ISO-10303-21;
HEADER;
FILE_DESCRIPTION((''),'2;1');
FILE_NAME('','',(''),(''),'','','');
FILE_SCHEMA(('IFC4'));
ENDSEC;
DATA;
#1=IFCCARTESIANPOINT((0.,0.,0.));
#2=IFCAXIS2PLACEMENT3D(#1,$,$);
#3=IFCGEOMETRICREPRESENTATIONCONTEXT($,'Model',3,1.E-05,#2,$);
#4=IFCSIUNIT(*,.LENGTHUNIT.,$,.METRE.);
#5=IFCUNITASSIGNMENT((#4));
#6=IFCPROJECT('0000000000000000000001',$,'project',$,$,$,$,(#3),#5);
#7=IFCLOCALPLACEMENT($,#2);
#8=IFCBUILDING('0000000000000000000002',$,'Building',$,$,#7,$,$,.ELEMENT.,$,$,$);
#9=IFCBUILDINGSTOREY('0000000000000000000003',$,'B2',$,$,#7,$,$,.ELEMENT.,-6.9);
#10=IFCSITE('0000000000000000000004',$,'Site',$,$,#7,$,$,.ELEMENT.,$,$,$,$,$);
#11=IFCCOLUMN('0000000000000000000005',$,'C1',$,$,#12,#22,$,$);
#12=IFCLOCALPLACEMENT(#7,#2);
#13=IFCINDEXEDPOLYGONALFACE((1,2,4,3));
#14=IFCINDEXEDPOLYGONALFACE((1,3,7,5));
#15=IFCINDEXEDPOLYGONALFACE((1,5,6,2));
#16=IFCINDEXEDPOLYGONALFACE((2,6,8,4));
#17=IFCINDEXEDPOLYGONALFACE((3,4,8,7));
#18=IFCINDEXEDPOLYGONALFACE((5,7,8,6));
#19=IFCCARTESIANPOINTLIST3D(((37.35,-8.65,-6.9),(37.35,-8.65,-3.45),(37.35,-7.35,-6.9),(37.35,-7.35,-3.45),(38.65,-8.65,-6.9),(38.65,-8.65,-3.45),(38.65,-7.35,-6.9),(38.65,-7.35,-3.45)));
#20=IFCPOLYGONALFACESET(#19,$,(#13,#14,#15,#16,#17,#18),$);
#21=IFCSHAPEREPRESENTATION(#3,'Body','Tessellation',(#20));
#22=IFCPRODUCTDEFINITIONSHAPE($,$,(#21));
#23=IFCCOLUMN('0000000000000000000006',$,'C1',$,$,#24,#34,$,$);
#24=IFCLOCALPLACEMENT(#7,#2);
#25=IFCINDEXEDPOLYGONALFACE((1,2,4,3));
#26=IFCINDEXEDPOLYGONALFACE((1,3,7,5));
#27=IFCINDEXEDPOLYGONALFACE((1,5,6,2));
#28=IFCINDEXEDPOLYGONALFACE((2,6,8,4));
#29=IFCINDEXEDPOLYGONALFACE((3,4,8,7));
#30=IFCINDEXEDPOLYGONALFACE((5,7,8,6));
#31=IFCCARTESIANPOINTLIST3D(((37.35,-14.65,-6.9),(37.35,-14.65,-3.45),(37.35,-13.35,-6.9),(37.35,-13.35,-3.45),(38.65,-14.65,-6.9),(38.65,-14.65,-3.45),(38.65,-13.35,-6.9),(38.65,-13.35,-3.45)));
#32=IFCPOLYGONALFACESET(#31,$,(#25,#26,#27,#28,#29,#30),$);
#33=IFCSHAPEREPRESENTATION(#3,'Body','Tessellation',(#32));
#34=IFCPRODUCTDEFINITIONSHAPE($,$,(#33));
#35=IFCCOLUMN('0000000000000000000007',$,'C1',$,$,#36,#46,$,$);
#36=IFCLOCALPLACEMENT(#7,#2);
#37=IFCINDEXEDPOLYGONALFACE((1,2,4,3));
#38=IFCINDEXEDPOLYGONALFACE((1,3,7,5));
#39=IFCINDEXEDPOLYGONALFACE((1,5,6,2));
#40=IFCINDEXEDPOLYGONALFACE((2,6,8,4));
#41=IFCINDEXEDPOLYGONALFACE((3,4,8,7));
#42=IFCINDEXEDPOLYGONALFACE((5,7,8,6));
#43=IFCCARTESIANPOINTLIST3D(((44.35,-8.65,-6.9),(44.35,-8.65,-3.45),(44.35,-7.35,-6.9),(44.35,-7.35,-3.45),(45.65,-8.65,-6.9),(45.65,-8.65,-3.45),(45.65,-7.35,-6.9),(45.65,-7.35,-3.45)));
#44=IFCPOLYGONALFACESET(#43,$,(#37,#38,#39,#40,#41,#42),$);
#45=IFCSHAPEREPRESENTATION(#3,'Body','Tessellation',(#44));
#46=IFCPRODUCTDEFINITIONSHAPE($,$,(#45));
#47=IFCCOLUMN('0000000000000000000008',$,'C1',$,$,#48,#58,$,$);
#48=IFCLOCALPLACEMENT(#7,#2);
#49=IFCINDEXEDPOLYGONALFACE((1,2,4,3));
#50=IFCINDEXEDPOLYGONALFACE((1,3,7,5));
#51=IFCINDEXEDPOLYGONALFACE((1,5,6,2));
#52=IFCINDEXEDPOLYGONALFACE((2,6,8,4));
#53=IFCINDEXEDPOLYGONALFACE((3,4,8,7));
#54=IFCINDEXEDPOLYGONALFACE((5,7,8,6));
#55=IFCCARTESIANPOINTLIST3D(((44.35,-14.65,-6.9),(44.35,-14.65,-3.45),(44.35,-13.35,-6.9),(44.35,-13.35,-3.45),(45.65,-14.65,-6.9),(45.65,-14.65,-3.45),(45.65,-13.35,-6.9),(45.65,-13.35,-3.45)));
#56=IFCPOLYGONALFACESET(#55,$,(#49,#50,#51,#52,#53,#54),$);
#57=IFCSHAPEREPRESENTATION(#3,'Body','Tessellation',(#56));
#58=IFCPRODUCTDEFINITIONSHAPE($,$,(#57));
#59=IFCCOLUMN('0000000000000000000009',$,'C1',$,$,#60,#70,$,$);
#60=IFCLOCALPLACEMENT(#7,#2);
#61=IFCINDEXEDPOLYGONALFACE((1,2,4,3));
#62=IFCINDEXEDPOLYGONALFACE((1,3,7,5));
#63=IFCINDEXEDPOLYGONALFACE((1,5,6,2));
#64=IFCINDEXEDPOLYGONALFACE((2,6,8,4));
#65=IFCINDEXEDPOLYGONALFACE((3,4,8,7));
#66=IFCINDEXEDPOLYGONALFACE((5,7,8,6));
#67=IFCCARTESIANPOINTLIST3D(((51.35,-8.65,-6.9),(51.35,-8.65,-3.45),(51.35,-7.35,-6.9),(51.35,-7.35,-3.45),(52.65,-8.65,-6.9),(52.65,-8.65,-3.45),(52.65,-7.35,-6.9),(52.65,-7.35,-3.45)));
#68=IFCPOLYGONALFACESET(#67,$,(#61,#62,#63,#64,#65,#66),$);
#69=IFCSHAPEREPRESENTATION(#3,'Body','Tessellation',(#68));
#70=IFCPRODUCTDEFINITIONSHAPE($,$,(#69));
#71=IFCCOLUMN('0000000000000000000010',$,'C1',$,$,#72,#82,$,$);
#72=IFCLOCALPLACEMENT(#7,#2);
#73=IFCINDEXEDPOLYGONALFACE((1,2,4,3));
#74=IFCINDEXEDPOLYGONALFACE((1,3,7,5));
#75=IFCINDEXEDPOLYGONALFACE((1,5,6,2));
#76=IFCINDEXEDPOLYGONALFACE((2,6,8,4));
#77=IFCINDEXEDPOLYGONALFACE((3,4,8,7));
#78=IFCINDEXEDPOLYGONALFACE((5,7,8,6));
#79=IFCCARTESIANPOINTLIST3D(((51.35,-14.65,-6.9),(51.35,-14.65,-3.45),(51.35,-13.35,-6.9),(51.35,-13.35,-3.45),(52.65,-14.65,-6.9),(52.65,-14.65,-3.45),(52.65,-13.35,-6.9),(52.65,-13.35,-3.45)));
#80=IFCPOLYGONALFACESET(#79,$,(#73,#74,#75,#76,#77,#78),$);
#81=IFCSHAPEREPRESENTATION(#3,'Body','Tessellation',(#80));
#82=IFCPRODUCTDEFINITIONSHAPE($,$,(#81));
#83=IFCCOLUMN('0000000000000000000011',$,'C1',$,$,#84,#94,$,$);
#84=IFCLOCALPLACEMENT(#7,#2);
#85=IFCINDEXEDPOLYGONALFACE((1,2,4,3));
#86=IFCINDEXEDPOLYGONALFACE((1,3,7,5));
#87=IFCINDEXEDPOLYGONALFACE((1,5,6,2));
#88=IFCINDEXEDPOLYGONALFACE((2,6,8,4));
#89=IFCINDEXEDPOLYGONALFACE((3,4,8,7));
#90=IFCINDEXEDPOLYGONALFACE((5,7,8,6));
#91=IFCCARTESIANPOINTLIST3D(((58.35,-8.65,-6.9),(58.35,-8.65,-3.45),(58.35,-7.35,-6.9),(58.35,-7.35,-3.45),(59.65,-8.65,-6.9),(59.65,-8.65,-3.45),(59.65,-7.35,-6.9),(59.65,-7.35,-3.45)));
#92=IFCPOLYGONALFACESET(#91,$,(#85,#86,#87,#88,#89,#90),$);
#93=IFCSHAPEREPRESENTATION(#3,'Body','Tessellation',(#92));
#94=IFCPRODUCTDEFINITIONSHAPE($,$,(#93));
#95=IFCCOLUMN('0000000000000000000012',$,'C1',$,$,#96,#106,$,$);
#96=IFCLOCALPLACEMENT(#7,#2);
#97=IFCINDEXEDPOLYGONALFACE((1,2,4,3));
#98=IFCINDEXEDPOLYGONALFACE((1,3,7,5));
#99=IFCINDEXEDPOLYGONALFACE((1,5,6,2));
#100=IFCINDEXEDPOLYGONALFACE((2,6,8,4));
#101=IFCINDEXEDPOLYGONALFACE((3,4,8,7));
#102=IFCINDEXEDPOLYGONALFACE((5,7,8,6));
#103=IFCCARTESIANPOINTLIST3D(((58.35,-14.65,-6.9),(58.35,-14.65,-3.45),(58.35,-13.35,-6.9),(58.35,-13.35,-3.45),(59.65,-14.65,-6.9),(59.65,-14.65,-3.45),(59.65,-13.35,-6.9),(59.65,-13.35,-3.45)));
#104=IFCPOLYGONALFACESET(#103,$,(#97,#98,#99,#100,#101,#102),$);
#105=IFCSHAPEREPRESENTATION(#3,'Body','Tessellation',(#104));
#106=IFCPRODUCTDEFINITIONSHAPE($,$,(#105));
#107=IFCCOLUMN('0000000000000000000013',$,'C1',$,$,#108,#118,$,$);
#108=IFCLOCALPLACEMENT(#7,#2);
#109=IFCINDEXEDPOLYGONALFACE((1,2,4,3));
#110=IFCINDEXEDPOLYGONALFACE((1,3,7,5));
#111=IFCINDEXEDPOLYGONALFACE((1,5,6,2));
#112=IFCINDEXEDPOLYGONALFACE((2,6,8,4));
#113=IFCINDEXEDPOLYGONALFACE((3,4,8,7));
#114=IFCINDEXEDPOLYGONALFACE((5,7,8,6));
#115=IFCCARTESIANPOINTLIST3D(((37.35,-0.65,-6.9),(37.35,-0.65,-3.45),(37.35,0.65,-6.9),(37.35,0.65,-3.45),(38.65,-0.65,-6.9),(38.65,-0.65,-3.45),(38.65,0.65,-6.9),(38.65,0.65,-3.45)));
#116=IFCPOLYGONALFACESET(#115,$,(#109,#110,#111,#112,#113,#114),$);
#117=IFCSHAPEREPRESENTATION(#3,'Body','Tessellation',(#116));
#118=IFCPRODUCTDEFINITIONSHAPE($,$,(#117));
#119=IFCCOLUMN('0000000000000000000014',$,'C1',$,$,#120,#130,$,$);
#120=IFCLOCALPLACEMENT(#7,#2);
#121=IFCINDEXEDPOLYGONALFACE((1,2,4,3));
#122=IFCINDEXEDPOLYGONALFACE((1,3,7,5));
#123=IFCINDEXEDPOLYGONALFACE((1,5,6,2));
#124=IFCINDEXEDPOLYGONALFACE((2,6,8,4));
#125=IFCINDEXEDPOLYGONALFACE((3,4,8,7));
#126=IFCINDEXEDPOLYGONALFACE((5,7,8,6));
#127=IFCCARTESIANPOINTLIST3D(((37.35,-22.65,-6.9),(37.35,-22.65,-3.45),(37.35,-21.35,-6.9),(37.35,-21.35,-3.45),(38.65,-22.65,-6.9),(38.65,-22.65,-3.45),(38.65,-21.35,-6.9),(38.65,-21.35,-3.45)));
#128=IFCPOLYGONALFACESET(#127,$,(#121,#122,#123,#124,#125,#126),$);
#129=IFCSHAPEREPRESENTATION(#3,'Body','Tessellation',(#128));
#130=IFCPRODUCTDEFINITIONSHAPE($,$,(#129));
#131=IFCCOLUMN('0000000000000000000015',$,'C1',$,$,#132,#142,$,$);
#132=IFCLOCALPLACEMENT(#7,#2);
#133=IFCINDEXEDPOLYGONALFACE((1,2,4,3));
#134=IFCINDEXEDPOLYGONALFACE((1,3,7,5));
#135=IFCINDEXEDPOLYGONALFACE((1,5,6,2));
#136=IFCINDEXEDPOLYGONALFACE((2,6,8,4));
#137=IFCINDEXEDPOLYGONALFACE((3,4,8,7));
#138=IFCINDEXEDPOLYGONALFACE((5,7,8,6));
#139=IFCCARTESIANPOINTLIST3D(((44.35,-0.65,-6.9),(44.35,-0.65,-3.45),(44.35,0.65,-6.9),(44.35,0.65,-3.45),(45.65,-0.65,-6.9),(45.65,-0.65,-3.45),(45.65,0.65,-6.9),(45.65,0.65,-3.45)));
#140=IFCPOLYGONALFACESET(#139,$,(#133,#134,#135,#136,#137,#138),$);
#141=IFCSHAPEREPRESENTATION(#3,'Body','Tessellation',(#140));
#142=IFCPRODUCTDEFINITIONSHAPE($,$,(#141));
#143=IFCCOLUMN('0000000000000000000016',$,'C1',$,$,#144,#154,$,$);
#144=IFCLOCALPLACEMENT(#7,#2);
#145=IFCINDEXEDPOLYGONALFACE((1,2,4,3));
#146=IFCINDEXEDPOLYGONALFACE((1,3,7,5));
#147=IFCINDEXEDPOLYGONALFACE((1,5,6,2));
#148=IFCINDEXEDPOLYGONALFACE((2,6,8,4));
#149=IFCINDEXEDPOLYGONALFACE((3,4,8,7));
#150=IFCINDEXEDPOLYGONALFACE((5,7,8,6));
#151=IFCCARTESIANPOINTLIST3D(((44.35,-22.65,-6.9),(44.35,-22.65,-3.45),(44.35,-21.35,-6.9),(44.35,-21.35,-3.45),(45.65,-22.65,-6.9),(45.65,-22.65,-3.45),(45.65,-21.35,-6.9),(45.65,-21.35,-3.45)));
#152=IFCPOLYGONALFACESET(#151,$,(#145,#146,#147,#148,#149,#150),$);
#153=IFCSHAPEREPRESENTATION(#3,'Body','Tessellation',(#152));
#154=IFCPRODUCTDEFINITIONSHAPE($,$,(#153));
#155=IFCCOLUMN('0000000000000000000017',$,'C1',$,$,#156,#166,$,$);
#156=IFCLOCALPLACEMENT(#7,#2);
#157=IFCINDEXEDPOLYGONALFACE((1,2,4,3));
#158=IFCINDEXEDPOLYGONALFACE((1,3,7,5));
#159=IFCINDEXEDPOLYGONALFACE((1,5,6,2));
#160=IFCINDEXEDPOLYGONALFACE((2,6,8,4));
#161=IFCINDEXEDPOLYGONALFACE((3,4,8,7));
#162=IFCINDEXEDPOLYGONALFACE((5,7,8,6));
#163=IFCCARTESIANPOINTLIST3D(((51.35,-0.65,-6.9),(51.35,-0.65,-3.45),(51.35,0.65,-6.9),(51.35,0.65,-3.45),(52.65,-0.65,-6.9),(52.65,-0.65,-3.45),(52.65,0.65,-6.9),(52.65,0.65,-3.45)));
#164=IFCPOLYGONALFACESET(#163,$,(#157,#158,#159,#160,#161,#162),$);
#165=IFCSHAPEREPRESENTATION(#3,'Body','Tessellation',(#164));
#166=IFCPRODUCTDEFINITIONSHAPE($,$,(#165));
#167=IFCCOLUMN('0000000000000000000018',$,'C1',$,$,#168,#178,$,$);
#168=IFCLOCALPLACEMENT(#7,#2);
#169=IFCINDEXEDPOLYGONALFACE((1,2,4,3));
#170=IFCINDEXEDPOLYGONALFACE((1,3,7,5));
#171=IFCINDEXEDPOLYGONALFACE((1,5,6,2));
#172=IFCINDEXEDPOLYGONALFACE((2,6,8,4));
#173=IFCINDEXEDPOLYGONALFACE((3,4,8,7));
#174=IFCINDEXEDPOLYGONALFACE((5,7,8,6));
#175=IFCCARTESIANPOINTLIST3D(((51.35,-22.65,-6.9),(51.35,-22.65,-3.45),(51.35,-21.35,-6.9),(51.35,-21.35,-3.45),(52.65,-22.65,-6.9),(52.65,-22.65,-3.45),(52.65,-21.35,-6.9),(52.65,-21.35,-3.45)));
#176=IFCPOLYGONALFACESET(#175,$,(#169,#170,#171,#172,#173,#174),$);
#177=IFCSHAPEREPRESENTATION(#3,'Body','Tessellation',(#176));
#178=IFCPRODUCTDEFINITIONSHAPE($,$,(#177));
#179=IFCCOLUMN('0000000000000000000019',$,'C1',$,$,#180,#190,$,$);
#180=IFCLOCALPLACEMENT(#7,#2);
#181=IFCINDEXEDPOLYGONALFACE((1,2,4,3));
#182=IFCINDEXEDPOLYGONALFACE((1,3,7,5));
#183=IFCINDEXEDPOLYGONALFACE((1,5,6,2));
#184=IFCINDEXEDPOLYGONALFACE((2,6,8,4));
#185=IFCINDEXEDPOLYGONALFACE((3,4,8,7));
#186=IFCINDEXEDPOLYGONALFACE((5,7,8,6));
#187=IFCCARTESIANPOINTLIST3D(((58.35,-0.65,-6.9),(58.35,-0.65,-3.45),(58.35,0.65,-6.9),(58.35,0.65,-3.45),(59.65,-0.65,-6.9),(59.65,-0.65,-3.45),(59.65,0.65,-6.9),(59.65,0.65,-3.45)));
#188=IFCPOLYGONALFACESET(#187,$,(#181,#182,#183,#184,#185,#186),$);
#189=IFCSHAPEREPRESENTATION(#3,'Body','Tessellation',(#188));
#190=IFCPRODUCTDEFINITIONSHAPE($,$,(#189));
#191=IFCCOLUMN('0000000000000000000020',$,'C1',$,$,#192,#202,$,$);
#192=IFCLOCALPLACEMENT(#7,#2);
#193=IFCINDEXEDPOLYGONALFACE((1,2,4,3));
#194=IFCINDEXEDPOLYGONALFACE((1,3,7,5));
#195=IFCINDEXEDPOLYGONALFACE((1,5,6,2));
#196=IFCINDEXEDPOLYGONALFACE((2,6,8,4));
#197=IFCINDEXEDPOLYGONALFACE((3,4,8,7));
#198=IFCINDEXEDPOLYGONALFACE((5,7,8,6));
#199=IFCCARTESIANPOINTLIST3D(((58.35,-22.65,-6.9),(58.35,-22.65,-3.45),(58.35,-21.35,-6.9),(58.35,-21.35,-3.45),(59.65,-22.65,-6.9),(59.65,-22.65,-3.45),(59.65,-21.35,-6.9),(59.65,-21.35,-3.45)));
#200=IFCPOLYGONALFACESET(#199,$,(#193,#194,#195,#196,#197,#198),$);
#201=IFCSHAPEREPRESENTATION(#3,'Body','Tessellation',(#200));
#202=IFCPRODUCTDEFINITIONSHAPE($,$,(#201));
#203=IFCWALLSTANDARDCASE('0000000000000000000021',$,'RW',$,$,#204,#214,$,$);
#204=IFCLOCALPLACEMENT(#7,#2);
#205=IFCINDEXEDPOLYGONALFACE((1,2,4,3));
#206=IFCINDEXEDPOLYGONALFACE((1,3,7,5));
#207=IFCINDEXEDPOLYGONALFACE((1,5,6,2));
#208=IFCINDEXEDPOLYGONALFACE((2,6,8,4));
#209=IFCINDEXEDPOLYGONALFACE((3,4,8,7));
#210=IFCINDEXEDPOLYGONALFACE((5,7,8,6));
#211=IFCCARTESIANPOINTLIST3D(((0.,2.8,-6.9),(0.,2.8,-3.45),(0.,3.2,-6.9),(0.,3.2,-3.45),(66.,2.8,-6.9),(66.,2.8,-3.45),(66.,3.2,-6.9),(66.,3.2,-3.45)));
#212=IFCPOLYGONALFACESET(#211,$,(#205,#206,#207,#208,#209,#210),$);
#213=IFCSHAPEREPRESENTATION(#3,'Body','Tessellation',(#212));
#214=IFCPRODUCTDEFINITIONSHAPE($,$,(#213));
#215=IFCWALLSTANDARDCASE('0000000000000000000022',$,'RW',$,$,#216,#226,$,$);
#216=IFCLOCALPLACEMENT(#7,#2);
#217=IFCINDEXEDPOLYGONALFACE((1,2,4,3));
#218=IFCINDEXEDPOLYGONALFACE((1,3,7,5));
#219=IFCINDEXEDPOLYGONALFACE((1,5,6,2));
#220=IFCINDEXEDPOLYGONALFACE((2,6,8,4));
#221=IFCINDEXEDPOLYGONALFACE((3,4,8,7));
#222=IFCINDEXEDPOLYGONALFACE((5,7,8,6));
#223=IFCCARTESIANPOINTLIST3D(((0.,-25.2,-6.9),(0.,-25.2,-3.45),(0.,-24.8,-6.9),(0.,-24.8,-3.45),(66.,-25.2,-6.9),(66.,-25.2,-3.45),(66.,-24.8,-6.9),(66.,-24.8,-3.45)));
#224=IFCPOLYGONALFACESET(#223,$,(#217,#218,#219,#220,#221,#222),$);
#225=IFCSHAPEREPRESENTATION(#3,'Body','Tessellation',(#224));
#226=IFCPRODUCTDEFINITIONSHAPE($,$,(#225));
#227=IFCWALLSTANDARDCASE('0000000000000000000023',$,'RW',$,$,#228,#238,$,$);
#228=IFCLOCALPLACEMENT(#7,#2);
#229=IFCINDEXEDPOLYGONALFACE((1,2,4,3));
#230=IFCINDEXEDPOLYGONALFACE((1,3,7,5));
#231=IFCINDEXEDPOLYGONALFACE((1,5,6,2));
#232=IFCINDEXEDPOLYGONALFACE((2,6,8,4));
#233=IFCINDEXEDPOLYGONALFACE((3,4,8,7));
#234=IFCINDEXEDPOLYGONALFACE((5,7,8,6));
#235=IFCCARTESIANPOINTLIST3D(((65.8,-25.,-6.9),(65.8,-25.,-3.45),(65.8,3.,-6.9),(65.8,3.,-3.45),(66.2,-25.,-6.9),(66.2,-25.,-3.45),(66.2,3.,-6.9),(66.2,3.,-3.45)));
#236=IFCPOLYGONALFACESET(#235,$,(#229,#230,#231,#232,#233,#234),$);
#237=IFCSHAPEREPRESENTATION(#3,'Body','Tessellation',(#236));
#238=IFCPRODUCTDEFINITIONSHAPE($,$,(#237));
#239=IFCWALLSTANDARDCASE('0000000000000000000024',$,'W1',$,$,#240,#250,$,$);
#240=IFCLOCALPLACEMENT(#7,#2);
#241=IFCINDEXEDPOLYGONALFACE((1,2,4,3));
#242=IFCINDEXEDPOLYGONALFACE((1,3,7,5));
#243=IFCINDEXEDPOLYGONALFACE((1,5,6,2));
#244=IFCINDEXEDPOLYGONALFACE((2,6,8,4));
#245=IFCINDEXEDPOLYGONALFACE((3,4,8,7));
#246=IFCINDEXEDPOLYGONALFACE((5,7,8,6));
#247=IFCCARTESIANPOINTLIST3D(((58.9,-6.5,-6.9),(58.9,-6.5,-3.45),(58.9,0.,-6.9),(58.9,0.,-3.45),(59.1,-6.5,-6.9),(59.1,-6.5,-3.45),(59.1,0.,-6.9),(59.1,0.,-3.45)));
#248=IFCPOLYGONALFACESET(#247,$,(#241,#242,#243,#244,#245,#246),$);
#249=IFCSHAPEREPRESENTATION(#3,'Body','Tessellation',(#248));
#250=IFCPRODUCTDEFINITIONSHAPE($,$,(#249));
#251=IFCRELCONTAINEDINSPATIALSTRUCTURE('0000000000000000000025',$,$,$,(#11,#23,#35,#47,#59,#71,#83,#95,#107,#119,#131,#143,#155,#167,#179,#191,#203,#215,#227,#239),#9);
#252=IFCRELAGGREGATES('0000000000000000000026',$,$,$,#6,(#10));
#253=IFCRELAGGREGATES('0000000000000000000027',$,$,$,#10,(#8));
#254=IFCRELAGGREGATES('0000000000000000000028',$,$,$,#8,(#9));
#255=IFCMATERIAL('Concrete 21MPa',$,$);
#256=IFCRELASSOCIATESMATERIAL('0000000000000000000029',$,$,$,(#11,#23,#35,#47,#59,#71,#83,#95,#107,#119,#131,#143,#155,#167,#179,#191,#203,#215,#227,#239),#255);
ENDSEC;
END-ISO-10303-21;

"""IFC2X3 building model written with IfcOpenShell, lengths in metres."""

from ifc_helpers import new_model, si_unit, frame, origin, origin_2d, place, context, project, spatial, rectangle, extrude, material, element, save


model = new_model("IFC2X3")

# Units and contexts
model_context = context("Model", 3, precision=1e-05, world=origin())
ifc_project = project(units=[si_unit("LENGTHUNIT", "METRE")], contexts=[model_context])

# Site, building, storey
placement = place(None, origin())
site = spatial("IfcSite", under=ifc_project, at=placement, Name="Site", CompositionType="ELEMENT")
building = spatial("IfcBuilding", under=site, at=placement, Name="Building", CompositionType="ELEMENT")
storey = spatial("IfcBuildingStorey", under=building, at=placement, Name="B2", CompositionType="ELEMENT", Elevation=-6.9)

# Columns
ifc_material_1 = material(Name="Concrete 21MPa")
for number, where, name in (
    (1, (38.0, -8.0, -6.9), "C1"),
    (2, (38.0, -14.0, -6.9), "C1"),
    (3, (45.0, -8.0, -6.9), "C1"),
    (4, (45.0, -14.0, -6.9), "C1"),
    (5, (52.0, -8.0, -6.9), "C1"),
    (6, (52.0, -14.0, -6.9), "C1"),
    (7, (59.0, -8.0, -6.9), "C1"),
    (8, (59.0, -14.0, -6.9), "C1"),
    (9, (38.0, 0.0, -6.9), "C1"),
    (10, (38.0, -22.0, -6.9), "C1"),
    (11, (45.0, 0.0, -6.9), "C1"),
    (12, (45.0, -22.0, -6.9), "C1"),
    (13, (52.0, 0.0, -6.9), "C1"),
    (14, (52.0, -22.0, -6.9), "C1"),
    (15, (59.0, 0.0, -6.9), "C1"),
    (16, (59.0, -22.0, -6.9), "C1"),
):
    element("IfcColumn", number, at=place(None, frame(where)), inside=storey, material=ifc_material_1, Name=name, context=model_context, shape_type="SweptSolid", body=[
        extrude(rectangle(XDim=1.3, YDim=1.3, at=origin_2d()), origin(), (0.0, 0.0, 1.0), 3.45),
    ])

# Walls
for number, where, name in (
    (17, (33.0, 3.0, -6.9), "RW"),
    (18, (33.0, -25.0, -6.9), "RW"),
):
    element("IfcWallStandardCase", number, at=place(None, frame(where)), inside=storey, material=ifc_material_1, Name=name, context=model_context, shape_type="SweptSolid", body=[
        extrude(rectangle(XDim=66.0, YDim=0.4, at=origin_2d()), origin(), (0.0, 0.0, 1.0), 3.45),
    ])
wall_1_placement = place(None, frame((66.0, -11.0, -6.9)))
element("IfcWallStandardCase", 19, at=wall_1_placement, inside=storey, material=ifc_material_1, Name="RW", context=model_context, shape_type="SweptSolid", body=[
    extrude(rectangle(XDim=0.4, YDim=28.0, at=origin_2d()), origin(), (0.0, 0.0, 1.0), 3.45),
])
wall_2_placement = place(None, frame((59.0, -3.25, -6.9)))
element("IfcWallStandardCase", 20, at=wall_2_placement, inside=storey, material=ifc_material_1, Name="W1", context=model_context, shape_type="SweptSolid", body=[
    extrude(rectangle(XDim=0.2, YDim=6.5, at=origin_2d()), origin(), (0.0, 0.0, 1.0), 3.45),
])

save(model, "model.ifc")
